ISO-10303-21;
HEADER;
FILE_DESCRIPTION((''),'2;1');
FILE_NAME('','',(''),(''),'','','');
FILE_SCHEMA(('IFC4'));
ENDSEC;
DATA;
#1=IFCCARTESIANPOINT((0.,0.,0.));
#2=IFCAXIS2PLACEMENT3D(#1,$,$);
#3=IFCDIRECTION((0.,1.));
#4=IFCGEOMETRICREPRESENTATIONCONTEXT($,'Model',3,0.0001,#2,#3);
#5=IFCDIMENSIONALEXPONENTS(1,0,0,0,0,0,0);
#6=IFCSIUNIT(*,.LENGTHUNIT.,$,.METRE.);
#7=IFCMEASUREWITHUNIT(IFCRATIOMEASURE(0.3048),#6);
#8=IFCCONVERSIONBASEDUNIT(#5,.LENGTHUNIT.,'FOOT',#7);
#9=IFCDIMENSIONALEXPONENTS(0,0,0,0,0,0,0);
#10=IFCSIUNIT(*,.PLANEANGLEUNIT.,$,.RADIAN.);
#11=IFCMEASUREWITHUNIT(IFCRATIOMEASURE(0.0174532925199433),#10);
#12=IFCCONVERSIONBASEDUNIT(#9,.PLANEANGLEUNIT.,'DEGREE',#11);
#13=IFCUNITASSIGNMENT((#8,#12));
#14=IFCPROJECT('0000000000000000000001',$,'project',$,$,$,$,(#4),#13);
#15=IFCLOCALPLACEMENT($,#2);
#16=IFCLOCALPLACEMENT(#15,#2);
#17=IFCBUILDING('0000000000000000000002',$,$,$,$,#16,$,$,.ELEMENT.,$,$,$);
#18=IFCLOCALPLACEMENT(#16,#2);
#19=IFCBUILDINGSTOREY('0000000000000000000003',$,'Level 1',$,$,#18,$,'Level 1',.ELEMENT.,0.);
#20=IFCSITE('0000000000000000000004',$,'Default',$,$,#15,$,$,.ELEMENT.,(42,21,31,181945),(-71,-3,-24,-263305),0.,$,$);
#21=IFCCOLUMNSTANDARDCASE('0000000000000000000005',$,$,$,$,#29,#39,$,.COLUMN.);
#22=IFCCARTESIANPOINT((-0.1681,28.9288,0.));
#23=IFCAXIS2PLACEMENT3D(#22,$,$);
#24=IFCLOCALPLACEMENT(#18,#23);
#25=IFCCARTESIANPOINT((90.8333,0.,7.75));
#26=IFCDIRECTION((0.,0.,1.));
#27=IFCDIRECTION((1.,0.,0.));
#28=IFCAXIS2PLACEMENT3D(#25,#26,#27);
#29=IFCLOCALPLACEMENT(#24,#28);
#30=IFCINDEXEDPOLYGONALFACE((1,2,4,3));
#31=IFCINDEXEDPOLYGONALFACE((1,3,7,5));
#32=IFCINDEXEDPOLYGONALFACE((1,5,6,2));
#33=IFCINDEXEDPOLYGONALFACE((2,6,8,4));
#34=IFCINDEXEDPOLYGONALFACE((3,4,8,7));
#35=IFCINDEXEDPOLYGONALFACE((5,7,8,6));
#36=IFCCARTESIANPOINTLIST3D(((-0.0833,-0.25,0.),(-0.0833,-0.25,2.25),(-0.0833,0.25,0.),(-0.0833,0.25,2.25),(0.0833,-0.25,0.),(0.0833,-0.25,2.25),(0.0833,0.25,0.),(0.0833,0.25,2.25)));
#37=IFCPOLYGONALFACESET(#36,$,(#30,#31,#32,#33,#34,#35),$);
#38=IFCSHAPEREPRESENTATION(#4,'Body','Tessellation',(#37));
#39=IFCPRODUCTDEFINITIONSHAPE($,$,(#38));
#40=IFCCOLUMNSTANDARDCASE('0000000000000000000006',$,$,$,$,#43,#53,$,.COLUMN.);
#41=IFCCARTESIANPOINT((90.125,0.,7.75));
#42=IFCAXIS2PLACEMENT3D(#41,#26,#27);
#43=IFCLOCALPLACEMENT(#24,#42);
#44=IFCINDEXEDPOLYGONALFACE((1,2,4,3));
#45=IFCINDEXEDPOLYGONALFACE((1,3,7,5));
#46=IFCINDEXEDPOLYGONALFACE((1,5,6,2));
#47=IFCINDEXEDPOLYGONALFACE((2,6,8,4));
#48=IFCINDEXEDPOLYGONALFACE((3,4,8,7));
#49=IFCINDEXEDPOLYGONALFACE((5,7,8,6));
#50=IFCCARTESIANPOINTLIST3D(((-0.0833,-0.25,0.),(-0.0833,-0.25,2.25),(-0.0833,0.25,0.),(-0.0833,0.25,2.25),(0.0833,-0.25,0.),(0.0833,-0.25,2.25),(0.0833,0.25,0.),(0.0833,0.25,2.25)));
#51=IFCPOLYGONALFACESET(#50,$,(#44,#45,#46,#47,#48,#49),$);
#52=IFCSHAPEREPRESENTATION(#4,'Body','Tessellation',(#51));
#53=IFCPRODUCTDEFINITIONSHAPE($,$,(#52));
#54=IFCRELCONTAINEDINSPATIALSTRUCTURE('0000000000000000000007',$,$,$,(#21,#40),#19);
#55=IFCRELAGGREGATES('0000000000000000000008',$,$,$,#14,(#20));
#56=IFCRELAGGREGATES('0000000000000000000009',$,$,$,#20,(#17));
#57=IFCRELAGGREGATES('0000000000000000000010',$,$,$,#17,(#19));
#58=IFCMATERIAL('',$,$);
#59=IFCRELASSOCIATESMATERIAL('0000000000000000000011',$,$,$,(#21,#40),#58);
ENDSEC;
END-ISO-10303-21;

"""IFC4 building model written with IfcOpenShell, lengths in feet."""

from ifc_helpers import new_model, entity, si_unit, converted_unit, direction, frame, origin, place, context, project, spatial, rectangle, extrude, material, element, save


model = new_model("IFC4")

# Units and contexts
model_context = context("Model", 3, precision=0.0001, world=origin(), true_north=direction((0.0, 1.0)))
ifc_project = project(units=[converted_unit("LENGTHUNIT", "FOOT", entity("IfcRatioMeasure", 0.3048), si_unit("LENGTHUNIT", "METRE"), dimensions=[1, 0, 0, 0, 0, 0, 0]), converted_unit("PLANEANGLEUNIT", "DEGREE", entity("IfcRatioMeasure", 0.0174532925199433), si_unit("PLANEANGLEUNIT", "RADIAN"), dimensions=[0, 0, 0, 0, 0, 0, 0])], contexts=[model_context])

# Site, building, storey
site_placement = place(None, origin())
site = spatial("IfcSite", under=ifc_project, at=site_placement, Name="Default", CompositionType="ELEMENT", RefLatitude=(42, 21, 31, 181945), RefLongitude=(-71, -3, -24, -263305), RefElevation=0.0)
building_placement = place(site_placement, origin())
building = spatial("IfcBuilding", under=site, at=building_placement, CompositionType="ELEMENT")
storey_placement = place(building_placement, origin())
storey = spatial("IfcBuildingStorey", under=building, at=storey_placement, Name="Level 1", LongName="Level 1", CompositionType="ELEMENT", Elevation=0.0)

# Columns
ifc_material = material(Name="")
placement = place(storey_placement, frame((-0.1681, 28.9288, 0.0)))
for number, where, z_axis, x_axis in (
    (1, (90.8333, 0.0, 7.75), (0.0, 0.0, 1.0), (1.0, 0.0, 0.0)),
    (2, (90.125, 0.0, 7.75), (0.0, 0.0, 1.0), (1.0, 0.0, 0.0)),
):
    element("IfcColumnStandardCase", number, at=place(placement, frame(where, z_axis=z_axis, x_axis=x_axis)), inside=storey, material=ifc_material, PredefinedType="COLUMN", context=model_context, shape_type="SweptSolid", body=[
        extrude(rectangle(XDim=0.1667, YDim=0.5), origin(), (0.0, 0.0, 1.0), 2.25),
    ])

save(model, "model.ifc")
